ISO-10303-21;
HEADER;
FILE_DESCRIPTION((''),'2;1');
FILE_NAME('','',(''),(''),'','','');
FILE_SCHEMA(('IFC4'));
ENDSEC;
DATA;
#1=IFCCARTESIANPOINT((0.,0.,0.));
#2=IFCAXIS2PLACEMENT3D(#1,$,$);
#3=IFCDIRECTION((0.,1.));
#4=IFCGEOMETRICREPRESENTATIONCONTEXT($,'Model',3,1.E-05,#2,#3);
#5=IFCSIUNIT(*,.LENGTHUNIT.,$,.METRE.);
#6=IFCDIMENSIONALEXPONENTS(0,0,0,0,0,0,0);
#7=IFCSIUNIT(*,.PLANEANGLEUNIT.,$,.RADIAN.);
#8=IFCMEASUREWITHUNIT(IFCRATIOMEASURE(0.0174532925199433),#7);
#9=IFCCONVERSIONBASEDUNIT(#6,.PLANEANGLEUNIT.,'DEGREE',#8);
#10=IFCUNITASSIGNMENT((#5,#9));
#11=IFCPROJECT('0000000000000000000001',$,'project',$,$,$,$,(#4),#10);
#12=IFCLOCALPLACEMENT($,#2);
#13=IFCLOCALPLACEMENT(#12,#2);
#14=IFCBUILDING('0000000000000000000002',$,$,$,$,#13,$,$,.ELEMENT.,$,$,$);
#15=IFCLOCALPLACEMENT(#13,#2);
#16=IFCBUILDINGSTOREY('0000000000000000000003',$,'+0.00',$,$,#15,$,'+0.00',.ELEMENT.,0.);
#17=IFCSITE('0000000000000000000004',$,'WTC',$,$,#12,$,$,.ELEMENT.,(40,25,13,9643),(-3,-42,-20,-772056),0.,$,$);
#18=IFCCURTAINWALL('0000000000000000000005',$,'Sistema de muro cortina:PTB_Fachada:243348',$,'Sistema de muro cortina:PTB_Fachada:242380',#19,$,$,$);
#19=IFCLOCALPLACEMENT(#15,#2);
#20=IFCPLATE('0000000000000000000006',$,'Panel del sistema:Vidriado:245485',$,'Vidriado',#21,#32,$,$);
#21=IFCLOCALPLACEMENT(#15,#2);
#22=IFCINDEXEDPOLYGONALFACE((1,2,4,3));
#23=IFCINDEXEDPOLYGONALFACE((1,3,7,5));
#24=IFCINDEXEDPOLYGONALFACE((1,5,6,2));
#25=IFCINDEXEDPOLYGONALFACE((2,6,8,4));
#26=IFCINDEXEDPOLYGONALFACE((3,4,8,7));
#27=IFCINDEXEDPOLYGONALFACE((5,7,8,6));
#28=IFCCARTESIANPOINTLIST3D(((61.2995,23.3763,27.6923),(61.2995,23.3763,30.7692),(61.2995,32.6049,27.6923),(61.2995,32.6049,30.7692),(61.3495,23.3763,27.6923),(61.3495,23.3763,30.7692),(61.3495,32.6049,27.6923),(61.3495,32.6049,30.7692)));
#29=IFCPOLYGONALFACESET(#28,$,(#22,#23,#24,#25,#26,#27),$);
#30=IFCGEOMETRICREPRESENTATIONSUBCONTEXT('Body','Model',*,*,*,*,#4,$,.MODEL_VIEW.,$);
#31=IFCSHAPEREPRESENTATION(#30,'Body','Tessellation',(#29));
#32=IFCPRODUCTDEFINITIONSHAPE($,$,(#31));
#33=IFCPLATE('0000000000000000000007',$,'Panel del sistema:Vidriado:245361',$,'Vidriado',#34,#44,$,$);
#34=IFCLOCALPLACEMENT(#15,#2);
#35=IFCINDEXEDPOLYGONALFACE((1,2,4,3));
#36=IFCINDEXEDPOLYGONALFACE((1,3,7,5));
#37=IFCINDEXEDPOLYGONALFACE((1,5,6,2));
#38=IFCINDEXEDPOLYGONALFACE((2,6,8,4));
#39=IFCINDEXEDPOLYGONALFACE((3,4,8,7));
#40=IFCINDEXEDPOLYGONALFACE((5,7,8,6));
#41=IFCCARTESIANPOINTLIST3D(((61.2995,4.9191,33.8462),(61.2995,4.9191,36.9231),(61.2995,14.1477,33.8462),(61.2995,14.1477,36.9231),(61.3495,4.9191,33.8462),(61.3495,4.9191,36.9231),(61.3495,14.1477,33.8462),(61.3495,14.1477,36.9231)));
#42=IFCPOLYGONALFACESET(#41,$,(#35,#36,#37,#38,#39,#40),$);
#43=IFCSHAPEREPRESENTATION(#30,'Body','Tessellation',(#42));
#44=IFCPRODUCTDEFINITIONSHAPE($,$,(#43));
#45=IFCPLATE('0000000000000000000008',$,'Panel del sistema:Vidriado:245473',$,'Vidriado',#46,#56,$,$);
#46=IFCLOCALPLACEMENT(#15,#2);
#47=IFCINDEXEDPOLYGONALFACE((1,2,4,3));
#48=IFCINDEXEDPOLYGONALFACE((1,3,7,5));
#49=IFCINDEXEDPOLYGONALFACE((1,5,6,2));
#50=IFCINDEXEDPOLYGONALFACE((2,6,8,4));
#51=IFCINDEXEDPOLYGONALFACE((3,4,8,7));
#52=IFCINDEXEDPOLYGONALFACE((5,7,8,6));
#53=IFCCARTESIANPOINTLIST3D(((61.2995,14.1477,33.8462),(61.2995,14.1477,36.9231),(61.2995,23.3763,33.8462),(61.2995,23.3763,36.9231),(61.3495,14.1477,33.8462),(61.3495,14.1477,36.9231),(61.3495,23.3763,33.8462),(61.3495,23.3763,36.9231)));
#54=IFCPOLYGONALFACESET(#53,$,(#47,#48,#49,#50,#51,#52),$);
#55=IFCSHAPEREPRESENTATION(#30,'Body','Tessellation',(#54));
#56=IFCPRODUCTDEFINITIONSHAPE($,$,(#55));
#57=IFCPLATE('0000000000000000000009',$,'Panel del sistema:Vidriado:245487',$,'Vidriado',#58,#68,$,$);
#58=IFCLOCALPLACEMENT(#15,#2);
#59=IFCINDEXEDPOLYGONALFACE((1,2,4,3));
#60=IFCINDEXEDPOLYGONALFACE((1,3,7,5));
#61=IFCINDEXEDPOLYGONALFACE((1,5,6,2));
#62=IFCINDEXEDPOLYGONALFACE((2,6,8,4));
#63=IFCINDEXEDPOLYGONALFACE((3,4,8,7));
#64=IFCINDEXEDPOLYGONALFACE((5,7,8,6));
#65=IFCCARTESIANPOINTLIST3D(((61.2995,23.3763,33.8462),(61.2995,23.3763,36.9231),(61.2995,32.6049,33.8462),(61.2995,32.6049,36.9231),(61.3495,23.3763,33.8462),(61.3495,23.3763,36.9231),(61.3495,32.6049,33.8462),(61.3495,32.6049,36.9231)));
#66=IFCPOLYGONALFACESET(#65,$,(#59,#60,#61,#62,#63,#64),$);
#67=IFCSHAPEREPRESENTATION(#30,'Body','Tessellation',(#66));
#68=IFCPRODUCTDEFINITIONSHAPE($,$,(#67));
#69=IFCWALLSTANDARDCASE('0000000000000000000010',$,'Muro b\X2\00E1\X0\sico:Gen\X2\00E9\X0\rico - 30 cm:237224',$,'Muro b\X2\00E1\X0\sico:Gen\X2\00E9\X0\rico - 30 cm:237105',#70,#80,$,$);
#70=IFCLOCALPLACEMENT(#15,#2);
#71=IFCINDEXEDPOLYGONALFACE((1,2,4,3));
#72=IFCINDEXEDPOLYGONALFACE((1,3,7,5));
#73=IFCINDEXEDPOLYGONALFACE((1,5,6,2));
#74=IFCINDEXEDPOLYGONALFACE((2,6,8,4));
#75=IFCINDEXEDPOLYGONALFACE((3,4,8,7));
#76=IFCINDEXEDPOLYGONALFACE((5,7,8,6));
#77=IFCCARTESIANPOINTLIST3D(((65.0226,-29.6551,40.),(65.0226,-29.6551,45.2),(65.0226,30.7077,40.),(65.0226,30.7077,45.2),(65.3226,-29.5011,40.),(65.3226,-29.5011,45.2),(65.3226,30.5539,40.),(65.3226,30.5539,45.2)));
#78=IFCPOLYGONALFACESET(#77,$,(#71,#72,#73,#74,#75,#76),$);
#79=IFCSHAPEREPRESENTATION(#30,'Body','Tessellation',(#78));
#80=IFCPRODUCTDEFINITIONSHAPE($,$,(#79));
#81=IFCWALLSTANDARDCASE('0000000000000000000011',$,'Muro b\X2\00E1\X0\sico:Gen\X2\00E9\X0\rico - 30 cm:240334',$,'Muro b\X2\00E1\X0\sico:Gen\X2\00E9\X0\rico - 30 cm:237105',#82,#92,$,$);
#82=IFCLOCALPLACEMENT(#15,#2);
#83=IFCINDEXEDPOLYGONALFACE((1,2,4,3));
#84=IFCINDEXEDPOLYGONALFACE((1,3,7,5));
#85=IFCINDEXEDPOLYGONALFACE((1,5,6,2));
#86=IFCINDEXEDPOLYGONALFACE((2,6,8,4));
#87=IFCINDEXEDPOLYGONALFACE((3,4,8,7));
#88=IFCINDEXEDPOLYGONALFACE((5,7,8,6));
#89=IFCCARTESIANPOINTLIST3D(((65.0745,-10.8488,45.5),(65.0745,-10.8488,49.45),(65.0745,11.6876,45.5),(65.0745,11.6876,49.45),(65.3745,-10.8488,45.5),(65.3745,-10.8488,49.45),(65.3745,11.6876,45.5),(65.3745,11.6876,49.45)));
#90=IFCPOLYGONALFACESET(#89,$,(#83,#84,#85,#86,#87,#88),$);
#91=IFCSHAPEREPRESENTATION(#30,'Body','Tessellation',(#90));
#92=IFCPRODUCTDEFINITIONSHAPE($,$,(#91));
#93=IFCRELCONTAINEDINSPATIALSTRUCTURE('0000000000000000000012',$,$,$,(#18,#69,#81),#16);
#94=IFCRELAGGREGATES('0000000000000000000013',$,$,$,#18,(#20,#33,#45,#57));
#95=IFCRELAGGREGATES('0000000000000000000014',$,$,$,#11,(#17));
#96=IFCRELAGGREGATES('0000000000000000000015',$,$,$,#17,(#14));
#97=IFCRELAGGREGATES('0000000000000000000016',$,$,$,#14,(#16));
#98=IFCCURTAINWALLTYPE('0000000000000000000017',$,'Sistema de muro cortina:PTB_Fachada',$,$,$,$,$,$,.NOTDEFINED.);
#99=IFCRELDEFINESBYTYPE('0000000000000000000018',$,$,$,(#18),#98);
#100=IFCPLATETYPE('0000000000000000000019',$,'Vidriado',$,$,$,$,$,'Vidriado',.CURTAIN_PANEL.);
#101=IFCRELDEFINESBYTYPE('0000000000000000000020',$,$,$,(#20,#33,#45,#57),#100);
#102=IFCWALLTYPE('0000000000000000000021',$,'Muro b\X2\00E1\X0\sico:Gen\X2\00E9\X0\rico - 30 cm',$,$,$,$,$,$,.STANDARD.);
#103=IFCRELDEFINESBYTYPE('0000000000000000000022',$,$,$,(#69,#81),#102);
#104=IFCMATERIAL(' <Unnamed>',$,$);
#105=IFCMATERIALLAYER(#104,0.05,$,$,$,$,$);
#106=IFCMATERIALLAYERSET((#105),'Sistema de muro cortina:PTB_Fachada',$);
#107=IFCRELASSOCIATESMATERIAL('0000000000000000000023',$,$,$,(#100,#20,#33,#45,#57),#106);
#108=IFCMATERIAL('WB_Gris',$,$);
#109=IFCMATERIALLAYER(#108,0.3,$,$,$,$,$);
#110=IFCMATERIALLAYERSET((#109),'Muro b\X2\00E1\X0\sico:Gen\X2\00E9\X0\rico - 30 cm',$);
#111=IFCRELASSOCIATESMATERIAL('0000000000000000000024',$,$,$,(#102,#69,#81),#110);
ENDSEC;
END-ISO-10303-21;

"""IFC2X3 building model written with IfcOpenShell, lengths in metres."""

from ifc_helpers import new_model, entity, si_unit, converted_unit, direction, frame, frame_2d, origin, origin_2d_with_axis, place, context, subcontext, project, spatial, polyline, rectangle, outline, extrude, clip, bounded_halfspace, source, transform, mapped, material, layer, layer_set, layer_usage, type_object, type_shapes, element, aggregate, save


model = new_model("IFC2X3")

# Units and contexts
model_context = context("Model", 3, precision=1e-05, world=origin(), true_north=direction((0.0, 1.0)))
body_context = subcontext(model_context, "Body", "Model", "MODEL_VIEW")
ifc_project = project(units=[si_unit("LENGTHUNIT", "METRE"), converted_unit("PLANEANGLEUNIT", "DEGREE", entity("IfcRatioMeasure", 0.0174532925199433), si_unit("PLANEANGLEUNIT", "RADIAN"), dimensions=[0, 0, 0, 0, 0, 0, 0])], contexts=[model_context])

# Site, building, storey
site_placement = place(None, origin())
site = spatial("IfcSite", under=ifc_project, at=site_placement, Name="WTC", CompositionType="ELEMENT", RefLatitude=(40, 25, 13, 9643), RefLongitude=(-3, -42, -20, -772056), RefElevation=0.0)
building_placement = place(site_placement, origin())
building = spatial("IfcBuilding", under=site, at=building_placement, CompositionType="ELEMENT")
storey_placement = place(building_placement, origin())
storey = spatial("IfcBuildingStorey", under=building, at=storey_placement, Name="+0.00", LongName="+0.00", CompositionType="ELEMENT", Elevation=0.0)

# Curtain wall, plates
curtain_wall_type = type_object("IfcCurtainWallType", Name="Sistema de muro cortina:PTB_Fachada", PredefinedType="NOTDEFINED")
ifc_material_1 = material(Name=" <Unnamed>")
ifc_layer_1 = layer(ifc_material_1, 0.05)
ifc_layer_set_1 = layer_set([ifc_layer_1], Name="Sistema de muro cortina:PTB_Fachada")
curtain_wall_1_placement = place(storey_placement, origin())
curtain_wall_1 = element("IfcCurtainWall", 1, at=curtain_wall_1_placement, inside=storey, type_object=curtain_wall_type, Name="Sistema de muro cortina:PTB_Fachada:243348", ObjectType="Sistema de muro cortina:PTB_Fachada:242380")
plate_type_1 = type_object("IfcPlateType", Name="Vidriado", ElementType="Vidriado", PredefinedType="CURTAIN_PANEL", material=ifc_layer_set_1)
shared_shape_1 = source(origin(), body_context, "Body", "SweptSolid", [
    extrude(rectangle(XDim=0.05, YDim=9.2286, at=origin_2d_with_axis()), frame((0.0, 0.0, 0.0), z_axis=(0.0, 0.0, 1.0), x_axis=(0.0, 1.0, 0.0)), (0.0, 0.0, 1.0), 3.0769),
])
type_shapes(plate_type_1, [shared_shape_1])
ifc_layer_usage_1 = layer_usage(ifc_layer_set_1, "AXIS3", "POSITIVE", 0.0)
plate_1_placement = place(curtain_wall_1_placement, frame((61.3245, 27.9906, 27.6923), z_axis=(0.0, 0.0, 1.0), x_axis=(0.0, 1.0, 0.0)))
plate_1 = element("IfcPlate", 2, at=plate_1_placement, type_object=plate_type_1, material=ifc_layer_usage_1, Name="Panel del sistema:Vidriado:245485", ObjectType="Vidriado", context=body_context, shape_type="MappedRepresentation", body=[
    mapped(shared_shape_1, transform((0.0, 0.0, 0.0), scale=1.0)),
])
ifc_layer_usage_2 = layer_usage(ifc_layer_set_1, "AXIS3", "POSITIVE", 0.0)
plate_2_placement = place(curtain_wall_1_placement, frame((61.3245, 9.5334, 33.8462), z_axis=(0.0, 0.0, 1.0), x_axis=(0.0, 1.0, 0.0)))
plate_2 = element("IfcPlate", 3, at=plate_2_placement, type_object=plate_type_1, material=ifc_layer_usage_2, Name="Panel del sistema:Vidriado:245361", ObjectType="Vidriado", context=body_context, shape_type="MappedRepresentation", body=[
    mapped(shared_shape_1, transform((0.0, 0.0, 0.0), scale=1.0)),
])
ifc_layer_usage_3 = layer_usage(ifc_layer_set_1, "AXIS3", "POSITIVE", 0.0)
plate_3_placement = place(curtain_wall_1_placement, frame((61.3245, 18.762, 33.8462), z_axis=(0.0, 0.0, 1.0), x_axis=(0.0, 1.0, 0.0)))
plate_3 = element("IfcPlate", 4, at=plate_3_placement, type_object=plate_type_1, material=ifc_layer_usage_3, Name="Panel del sistema:Vidriado:245473", ObjectType="Vidriado", context=body_context, shape_type="MappedRepresentation", body=[
    mapped(shared_shape_1, transform((0.0, 0.0, 0.0), scale=1.0)),
])
ifc_layer_usage_4 = layer_usage(ifc_layer_set_1, "AXIS3", "POSITIVE", 0.0)
plate_4_placement = place(curtain_wall_1_placement, frame((61.3245, 27.9906, 33.8462), z_axis=(0.0, 0.0, 1.0), x_axis=(0.0, 1.0, 0.0)))
plate_4 = element("IfcPlate", 5, at=plate_4_placement, type_object=plate_type_1, material=ifc_layer_usage_4, Name="Panel del sistema:Vidriado:245487", ObjectType="Vidriado", context=body_context, shape_type="MappedRepresentation", body=[
    mapped(shared_shape_1, transform((0.0, 0.0, 0.0), scale=1.0)),
])
aggregate(curtain_wall_1, [plate_1, plate_2, plate_3, plate_4])

# Walls
ifc_material_2 = material(Name="WB_Gris")
ifc_layer_2 = layer(ifc_material_2, 0.3)
ifc_layer_set_2 = layer_set([ifc_layer_2], Name="Muro básico:Genérico - 30 cm")
ifc_layer_usage_5 = layer_usage(ifc_layer_set_2, "AXIS2", "POSITIVE", -0.15)
wall_type = type_object("IfcWallType", Name="Muro básico:Genérico - 30 cm", PredefinedType="STANDARD", material=ifc_layer_set_2)
wall_1_placement = place(storey_placement, frame((65.1726, 30.7077, 40.0), z_axis=(0.0, 0.0, 1.0), x_axis=(0.0, -1.0, 0.0)))
element("IfcWallStandardCase", 6, at=wall_1_placement, inside=storey, type_object=wall_type, material=ifc_layer_usage_5, Name="Muro básico:Genérico - 30 cm:237224", ObjectType="Muro básico:Genérico - 30 cm:237105", context=body_context, shape_type="Clipping", body=[
    clip(extrude(outline(polyline([(60.3628, -0.15), (60.2088, 0.15), (0.4909, 0.15), (0.1538, 0.15), (0.0, -0.15), (60.3628, -0.15)])), origin(), (0.0, 0.0, 1.0), 5.2), bounded_halfspace(frame((0.0, -0.15, 5.2), z_axis=(0.0, 0.0, 1.0), x_axis=(0.0, 1.0, 0.0)), False, frame((0.0, -0.15, 5.2), z_axis=(0.0, 0.0, 1.0), x_axis=(0.0, 1.0, 0.0)), polyline([(0.0, 0.0), (0.0, -60.3628), (0.3, -60.2088), (0.3, -0.1538), (0.0, 0.0)]))),
])
ifc_layer_usage_6 = layer_usage(ifc_layer_set_2, "AXIS2", "POSITIVE", -0.15)
wall_2_placement = place(storey_placement, frame((65.2245, 11.6876, 45.5), z_axis=(0.0, 0.0, 1.0), x_axis=(0.0, -1.0, 0.0)))
element("IfcWallStandardCase", 7, at=wall_2_placement, inside=storey, type_object=wall_type, material=ifc_layer_usage_6, Name="Muro básico:Genérico - 30 cm:240334", ObjectType="Muro básico:Genérico - 30 cm:237105", context=body_context, shape_type="Clipping", body=[
    clip(extrude(rectangle(XDim=22.5364, YDim=0.3, at=frame_2d((11.2682, 0.0), x_axis=(-1.0, 0.0))), origin(), (0.0, 0.0, 1.0), 3.95), bounded_halfspace(frame((0.0, -0.15, 3.95), z_axis=(0.0, 0.0, 1.0), x_axis=(0.0, -1.0, 0.0)), False, frame((0.0, -0.15, 3.95), z_axis=(0.0, 0.0, 1.0), x_axis=(0.0, -1.0, 0.0)), polyline([(0.0, 0.0), (0.0, 22.5364), (-0.3, 22.5364), (-0.3, 0.3), (-0.3, 0.0), (0.0, 0.0)]))),
])

save(model, "model.ifc")
